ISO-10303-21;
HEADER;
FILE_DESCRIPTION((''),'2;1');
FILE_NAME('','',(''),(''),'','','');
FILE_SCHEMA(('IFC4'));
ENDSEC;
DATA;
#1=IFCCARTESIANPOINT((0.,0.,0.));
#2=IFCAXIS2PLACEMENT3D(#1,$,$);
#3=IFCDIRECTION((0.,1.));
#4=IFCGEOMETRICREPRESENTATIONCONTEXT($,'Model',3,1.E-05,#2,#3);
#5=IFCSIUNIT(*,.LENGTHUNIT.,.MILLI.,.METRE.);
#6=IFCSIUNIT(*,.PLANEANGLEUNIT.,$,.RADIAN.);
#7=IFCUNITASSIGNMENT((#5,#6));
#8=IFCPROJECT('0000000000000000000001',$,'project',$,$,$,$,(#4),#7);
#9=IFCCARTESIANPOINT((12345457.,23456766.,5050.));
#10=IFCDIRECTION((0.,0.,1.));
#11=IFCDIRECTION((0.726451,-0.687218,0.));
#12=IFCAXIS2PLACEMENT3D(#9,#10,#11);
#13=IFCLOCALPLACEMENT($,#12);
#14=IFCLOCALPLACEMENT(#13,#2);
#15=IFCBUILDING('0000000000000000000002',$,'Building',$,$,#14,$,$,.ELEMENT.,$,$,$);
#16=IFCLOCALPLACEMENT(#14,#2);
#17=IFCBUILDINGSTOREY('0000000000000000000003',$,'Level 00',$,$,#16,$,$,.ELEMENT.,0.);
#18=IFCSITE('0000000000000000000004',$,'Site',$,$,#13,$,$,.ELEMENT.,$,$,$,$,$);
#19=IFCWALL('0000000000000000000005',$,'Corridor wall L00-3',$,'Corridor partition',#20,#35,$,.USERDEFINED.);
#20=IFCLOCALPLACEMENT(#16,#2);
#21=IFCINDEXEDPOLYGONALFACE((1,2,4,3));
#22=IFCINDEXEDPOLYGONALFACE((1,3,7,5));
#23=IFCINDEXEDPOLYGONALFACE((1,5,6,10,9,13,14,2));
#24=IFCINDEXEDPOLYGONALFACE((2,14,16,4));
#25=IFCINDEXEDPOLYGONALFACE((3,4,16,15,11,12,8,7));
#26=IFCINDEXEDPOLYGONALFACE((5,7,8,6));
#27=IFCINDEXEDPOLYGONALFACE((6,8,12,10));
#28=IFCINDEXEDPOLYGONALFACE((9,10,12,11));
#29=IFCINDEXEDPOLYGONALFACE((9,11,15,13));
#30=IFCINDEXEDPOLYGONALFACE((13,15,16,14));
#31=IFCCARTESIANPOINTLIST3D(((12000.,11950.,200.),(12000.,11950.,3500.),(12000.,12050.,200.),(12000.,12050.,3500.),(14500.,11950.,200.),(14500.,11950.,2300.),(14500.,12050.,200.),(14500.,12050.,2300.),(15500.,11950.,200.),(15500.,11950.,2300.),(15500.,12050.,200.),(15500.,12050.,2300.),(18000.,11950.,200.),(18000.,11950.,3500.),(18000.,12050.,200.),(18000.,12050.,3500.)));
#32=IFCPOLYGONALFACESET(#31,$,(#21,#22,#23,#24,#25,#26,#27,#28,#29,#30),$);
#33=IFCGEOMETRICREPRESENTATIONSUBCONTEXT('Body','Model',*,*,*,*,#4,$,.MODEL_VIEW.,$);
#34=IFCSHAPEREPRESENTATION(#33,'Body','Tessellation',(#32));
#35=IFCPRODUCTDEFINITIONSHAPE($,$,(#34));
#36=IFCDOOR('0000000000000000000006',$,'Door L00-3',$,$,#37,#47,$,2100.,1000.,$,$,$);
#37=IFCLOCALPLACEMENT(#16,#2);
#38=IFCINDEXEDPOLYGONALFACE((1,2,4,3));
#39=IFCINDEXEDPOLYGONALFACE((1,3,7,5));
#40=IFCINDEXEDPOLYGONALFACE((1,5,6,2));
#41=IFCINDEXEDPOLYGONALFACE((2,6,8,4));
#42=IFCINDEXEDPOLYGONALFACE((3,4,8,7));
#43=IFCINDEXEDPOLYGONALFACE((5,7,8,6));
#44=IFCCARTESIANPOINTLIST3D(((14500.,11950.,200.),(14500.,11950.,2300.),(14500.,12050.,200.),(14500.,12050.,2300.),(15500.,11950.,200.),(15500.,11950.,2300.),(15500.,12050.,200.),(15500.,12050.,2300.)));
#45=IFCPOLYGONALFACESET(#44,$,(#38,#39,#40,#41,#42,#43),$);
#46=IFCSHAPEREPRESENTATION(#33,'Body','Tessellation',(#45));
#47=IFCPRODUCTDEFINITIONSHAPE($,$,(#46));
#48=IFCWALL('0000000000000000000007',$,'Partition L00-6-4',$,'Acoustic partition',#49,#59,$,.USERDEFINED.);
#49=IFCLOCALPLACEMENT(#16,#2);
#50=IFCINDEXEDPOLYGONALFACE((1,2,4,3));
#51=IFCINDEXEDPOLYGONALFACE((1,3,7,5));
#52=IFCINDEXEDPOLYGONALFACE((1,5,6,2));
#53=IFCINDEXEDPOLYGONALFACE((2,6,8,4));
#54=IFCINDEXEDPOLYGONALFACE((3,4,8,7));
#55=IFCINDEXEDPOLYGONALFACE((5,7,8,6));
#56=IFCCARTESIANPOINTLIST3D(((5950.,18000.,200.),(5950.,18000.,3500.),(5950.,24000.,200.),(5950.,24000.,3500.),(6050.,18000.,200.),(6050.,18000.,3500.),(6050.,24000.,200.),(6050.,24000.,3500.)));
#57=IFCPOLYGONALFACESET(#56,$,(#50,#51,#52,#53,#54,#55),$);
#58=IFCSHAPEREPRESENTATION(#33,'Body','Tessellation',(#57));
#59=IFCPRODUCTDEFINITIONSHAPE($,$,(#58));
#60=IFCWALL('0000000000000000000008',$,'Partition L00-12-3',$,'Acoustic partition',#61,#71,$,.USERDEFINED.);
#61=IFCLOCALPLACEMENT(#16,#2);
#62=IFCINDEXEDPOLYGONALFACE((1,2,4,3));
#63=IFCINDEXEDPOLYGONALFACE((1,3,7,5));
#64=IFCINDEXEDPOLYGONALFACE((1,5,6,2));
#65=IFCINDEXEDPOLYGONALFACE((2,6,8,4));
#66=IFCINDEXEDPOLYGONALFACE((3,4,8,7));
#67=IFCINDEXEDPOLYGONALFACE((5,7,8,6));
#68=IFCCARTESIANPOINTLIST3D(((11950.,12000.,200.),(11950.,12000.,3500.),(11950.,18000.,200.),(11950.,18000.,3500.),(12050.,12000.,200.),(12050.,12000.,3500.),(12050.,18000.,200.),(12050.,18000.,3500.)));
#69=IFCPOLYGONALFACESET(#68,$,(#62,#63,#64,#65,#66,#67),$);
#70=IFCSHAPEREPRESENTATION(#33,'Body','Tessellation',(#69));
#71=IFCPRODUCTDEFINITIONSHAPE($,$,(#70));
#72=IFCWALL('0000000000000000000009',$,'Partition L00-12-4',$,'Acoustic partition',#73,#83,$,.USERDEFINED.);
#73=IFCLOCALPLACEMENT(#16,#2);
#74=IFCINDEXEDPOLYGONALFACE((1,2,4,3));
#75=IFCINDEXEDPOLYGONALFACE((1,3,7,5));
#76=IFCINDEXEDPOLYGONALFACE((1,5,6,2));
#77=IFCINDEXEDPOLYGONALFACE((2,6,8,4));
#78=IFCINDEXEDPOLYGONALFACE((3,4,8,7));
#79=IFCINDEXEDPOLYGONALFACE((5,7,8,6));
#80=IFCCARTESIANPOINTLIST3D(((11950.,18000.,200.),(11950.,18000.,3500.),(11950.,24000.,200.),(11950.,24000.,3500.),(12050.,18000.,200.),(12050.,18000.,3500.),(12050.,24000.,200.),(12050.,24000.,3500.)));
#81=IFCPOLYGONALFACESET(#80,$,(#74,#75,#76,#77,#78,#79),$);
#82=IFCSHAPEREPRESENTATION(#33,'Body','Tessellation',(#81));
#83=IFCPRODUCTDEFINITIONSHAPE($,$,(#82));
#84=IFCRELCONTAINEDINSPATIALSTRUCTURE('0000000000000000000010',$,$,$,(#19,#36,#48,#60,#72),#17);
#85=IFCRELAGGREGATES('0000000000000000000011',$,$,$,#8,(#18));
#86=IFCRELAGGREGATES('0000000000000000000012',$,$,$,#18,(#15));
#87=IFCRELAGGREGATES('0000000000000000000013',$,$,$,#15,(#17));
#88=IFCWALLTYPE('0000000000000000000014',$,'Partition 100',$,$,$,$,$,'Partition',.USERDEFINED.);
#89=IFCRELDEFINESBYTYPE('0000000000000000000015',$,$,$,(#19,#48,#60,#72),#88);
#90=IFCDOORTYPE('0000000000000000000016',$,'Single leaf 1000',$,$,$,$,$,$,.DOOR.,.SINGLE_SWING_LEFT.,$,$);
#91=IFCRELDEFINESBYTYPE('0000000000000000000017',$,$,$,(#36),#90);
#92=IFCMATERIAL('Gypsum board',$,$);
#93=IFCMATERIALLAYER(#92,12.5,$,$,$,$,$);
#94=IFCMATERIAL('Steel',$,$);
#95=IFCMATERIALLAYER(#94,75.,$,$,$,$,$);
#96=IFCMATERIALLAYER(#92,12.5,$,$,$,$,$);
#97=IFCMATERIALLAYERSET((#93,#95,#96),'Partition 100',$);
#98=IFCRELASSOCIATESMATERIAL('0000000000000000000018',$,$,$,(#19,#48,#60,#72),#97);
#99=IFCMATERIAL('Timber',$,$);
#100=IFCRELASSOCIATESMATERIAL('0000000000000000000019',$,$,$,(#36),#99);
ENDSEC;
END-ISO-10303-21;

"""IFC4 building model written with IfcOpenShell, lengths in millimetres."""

from ifc_helpers import new_model, si_unit, direction, frame, origin, place, context, subcontext, project, spatial, rectangle, extrude, source, transform, mapped, material, layer, layer_set, layer_usage, type_object, type_shapes, element, fill, save


model = new_model("IFC4")

# Units and contexts
model_context = context("Model", 3, precision=1e-05, world=origin(), true_north=direction((0.0, 1.0)))
body_context = subcontext(model_context, "Body", "Model", "MODEL_VIEW")
ifc_project = project(units=[si_unit("LENGTHUNIT", "METRE", prefix="MILLI"), si_unit("PLANEANGLEUNIT", "RADIAN")], contexts=[model_context])

# Site, building, storey
site_placement = place(None, frame((12345457.0, 23456766.0, 5050.0), z_axis=(0.0, 0.0, 1.0), x_axis=(0.726451, -0.687218, 0.0)))
site = spatial("IfcSite", under=ifc_project, at=site_placement, Name="Site", CompositionType="ELEMENT")
building_placement = place(site_placement, origin())
building = spatial("IfcBuilding", under=site, at=building_placement, Name="Building", CompositionType="ELEMENT")
storey_placement = place(building_placement, origin())
storey = spatial("IfcBuildingStorey", under=building, at=storey_placement, Name="Level 00", CompositionType="ELEMENT", Elevation=0.0)

# Shared definitions
ifc_material_1 = material(Name="Steel")

# Wall, opening, door
ifc_material_2 = material(Name="Gypsum board")
ifc_layer_1 = layer(ifc_material_2, 12.5)
ifc_layer_2 = layer(ifc_material_1, 75.0)
ifc_layer_3 = layer(ifc_material_2, 12.5)
ifc_layer_set_1 = layer_set([ifc_layer_1, ifc_layer_2, ifc_layer_3], Name="Partition 100")
ifc_layer_usage_1 = layer_usage(ifc_layer_set_1, "AXIS2", "POSITIVE", 0.0)
wall_type_1 = type_object("IfcWallType", Name="Partition 100", ElementType="Partition", PredefinedType="USERDEFINED")
wall_placement = place(storey_placement, frame((12000.0, 11950.0, 200.0)))
wall = element("IfcWall", 1, at=wall_placement, inside=storey, type_object=wall_type_1, material=ifc_layer_usage_1, Name="Corridor wall L00-3", ObjectType="Corridor partition", PredefinedType="USERDEFINED", context=body_context, shape_type="SweptSolid", body=[
    extrude(rectangle(XDim=6000.0, YDim=100.0), frame((3000.0, 50.0, 0.0)), (0.0, 0.0, 1.0), 3300.0),
])
opening_placement = place(wall_placement, frame((2500.0, -50.0, 0.0)))
opening = element("IfcOpeningElement", 2, at=opening_placement, cuts=wall, PredefinedType="OPENING", context=body_context, shape_type="SweptSolid", body=[
    extrude(rectangle(XDim=1000.0, YDim=200.0), frame((500.0, 100.0, 0.0)), (0.0, 0.0, 1.0), 2100.0),
])
ifc_material_3 = material(Name="Timber")
door_type = type_object("IfcDoorType", Name="Single leaf 1000", OperationType="SINGLE_SWING_LEFT", PredefinedType="DOOR")
shared_shape = source(origin(), body_context, "Body", "SweptSolid", [
    extrude(rectangle(XDim=1000.0, YDim=100.0), frame((500.0, 50.0, 0.0)), (0.0, 0.0, 1.0), 2100.0),
])
type_shapes(door_type, [shared_shape])
door_placement = place(storey_placement, frame((14500.0, 11950.0, 200.0)))
door = element("IfcDoor", 3, at=door_placement, inside=storey, type_object=door_type, material=ifc_material_3, Name="Door L00-3", OverallHeight=2100.0, OverallWidth=1000.0, context=body_context, shape_type="MappedRepresentation", body=[
    mapped(shared_shape, transform((0.0, 0.0, 0.0))),
])
fill(opening, door)

# Walls
for number, where, name in (
    (4, (5950.0, 18000.0, 200.0), "Partition L00-6-4"),
    (5, (11950.0, 12000.0, 200.0), "Partition L00-12-3"),
    (6, (11950.0, 18000.0, 200.0), "Partition L00-12-4"),
):
    element("IfcWall", number, at=place(storey_placement, frame(where)), inside=storey, type_object=wall_type_1, material=ifc_layer_usage_1, Name=name, ObjectType="Acoustic partition", PredefinedType="USERDEFINED", context=body_context, shape_type="SweptSolid", body=[
        extrude(rectangle(XDim=100.0, YDim=6000.0), frame((50.0, 3000.0, 0.0)), (0.0, 0.0, 1.0), 3300.0),
    ])

save(model, "model.ifc")
